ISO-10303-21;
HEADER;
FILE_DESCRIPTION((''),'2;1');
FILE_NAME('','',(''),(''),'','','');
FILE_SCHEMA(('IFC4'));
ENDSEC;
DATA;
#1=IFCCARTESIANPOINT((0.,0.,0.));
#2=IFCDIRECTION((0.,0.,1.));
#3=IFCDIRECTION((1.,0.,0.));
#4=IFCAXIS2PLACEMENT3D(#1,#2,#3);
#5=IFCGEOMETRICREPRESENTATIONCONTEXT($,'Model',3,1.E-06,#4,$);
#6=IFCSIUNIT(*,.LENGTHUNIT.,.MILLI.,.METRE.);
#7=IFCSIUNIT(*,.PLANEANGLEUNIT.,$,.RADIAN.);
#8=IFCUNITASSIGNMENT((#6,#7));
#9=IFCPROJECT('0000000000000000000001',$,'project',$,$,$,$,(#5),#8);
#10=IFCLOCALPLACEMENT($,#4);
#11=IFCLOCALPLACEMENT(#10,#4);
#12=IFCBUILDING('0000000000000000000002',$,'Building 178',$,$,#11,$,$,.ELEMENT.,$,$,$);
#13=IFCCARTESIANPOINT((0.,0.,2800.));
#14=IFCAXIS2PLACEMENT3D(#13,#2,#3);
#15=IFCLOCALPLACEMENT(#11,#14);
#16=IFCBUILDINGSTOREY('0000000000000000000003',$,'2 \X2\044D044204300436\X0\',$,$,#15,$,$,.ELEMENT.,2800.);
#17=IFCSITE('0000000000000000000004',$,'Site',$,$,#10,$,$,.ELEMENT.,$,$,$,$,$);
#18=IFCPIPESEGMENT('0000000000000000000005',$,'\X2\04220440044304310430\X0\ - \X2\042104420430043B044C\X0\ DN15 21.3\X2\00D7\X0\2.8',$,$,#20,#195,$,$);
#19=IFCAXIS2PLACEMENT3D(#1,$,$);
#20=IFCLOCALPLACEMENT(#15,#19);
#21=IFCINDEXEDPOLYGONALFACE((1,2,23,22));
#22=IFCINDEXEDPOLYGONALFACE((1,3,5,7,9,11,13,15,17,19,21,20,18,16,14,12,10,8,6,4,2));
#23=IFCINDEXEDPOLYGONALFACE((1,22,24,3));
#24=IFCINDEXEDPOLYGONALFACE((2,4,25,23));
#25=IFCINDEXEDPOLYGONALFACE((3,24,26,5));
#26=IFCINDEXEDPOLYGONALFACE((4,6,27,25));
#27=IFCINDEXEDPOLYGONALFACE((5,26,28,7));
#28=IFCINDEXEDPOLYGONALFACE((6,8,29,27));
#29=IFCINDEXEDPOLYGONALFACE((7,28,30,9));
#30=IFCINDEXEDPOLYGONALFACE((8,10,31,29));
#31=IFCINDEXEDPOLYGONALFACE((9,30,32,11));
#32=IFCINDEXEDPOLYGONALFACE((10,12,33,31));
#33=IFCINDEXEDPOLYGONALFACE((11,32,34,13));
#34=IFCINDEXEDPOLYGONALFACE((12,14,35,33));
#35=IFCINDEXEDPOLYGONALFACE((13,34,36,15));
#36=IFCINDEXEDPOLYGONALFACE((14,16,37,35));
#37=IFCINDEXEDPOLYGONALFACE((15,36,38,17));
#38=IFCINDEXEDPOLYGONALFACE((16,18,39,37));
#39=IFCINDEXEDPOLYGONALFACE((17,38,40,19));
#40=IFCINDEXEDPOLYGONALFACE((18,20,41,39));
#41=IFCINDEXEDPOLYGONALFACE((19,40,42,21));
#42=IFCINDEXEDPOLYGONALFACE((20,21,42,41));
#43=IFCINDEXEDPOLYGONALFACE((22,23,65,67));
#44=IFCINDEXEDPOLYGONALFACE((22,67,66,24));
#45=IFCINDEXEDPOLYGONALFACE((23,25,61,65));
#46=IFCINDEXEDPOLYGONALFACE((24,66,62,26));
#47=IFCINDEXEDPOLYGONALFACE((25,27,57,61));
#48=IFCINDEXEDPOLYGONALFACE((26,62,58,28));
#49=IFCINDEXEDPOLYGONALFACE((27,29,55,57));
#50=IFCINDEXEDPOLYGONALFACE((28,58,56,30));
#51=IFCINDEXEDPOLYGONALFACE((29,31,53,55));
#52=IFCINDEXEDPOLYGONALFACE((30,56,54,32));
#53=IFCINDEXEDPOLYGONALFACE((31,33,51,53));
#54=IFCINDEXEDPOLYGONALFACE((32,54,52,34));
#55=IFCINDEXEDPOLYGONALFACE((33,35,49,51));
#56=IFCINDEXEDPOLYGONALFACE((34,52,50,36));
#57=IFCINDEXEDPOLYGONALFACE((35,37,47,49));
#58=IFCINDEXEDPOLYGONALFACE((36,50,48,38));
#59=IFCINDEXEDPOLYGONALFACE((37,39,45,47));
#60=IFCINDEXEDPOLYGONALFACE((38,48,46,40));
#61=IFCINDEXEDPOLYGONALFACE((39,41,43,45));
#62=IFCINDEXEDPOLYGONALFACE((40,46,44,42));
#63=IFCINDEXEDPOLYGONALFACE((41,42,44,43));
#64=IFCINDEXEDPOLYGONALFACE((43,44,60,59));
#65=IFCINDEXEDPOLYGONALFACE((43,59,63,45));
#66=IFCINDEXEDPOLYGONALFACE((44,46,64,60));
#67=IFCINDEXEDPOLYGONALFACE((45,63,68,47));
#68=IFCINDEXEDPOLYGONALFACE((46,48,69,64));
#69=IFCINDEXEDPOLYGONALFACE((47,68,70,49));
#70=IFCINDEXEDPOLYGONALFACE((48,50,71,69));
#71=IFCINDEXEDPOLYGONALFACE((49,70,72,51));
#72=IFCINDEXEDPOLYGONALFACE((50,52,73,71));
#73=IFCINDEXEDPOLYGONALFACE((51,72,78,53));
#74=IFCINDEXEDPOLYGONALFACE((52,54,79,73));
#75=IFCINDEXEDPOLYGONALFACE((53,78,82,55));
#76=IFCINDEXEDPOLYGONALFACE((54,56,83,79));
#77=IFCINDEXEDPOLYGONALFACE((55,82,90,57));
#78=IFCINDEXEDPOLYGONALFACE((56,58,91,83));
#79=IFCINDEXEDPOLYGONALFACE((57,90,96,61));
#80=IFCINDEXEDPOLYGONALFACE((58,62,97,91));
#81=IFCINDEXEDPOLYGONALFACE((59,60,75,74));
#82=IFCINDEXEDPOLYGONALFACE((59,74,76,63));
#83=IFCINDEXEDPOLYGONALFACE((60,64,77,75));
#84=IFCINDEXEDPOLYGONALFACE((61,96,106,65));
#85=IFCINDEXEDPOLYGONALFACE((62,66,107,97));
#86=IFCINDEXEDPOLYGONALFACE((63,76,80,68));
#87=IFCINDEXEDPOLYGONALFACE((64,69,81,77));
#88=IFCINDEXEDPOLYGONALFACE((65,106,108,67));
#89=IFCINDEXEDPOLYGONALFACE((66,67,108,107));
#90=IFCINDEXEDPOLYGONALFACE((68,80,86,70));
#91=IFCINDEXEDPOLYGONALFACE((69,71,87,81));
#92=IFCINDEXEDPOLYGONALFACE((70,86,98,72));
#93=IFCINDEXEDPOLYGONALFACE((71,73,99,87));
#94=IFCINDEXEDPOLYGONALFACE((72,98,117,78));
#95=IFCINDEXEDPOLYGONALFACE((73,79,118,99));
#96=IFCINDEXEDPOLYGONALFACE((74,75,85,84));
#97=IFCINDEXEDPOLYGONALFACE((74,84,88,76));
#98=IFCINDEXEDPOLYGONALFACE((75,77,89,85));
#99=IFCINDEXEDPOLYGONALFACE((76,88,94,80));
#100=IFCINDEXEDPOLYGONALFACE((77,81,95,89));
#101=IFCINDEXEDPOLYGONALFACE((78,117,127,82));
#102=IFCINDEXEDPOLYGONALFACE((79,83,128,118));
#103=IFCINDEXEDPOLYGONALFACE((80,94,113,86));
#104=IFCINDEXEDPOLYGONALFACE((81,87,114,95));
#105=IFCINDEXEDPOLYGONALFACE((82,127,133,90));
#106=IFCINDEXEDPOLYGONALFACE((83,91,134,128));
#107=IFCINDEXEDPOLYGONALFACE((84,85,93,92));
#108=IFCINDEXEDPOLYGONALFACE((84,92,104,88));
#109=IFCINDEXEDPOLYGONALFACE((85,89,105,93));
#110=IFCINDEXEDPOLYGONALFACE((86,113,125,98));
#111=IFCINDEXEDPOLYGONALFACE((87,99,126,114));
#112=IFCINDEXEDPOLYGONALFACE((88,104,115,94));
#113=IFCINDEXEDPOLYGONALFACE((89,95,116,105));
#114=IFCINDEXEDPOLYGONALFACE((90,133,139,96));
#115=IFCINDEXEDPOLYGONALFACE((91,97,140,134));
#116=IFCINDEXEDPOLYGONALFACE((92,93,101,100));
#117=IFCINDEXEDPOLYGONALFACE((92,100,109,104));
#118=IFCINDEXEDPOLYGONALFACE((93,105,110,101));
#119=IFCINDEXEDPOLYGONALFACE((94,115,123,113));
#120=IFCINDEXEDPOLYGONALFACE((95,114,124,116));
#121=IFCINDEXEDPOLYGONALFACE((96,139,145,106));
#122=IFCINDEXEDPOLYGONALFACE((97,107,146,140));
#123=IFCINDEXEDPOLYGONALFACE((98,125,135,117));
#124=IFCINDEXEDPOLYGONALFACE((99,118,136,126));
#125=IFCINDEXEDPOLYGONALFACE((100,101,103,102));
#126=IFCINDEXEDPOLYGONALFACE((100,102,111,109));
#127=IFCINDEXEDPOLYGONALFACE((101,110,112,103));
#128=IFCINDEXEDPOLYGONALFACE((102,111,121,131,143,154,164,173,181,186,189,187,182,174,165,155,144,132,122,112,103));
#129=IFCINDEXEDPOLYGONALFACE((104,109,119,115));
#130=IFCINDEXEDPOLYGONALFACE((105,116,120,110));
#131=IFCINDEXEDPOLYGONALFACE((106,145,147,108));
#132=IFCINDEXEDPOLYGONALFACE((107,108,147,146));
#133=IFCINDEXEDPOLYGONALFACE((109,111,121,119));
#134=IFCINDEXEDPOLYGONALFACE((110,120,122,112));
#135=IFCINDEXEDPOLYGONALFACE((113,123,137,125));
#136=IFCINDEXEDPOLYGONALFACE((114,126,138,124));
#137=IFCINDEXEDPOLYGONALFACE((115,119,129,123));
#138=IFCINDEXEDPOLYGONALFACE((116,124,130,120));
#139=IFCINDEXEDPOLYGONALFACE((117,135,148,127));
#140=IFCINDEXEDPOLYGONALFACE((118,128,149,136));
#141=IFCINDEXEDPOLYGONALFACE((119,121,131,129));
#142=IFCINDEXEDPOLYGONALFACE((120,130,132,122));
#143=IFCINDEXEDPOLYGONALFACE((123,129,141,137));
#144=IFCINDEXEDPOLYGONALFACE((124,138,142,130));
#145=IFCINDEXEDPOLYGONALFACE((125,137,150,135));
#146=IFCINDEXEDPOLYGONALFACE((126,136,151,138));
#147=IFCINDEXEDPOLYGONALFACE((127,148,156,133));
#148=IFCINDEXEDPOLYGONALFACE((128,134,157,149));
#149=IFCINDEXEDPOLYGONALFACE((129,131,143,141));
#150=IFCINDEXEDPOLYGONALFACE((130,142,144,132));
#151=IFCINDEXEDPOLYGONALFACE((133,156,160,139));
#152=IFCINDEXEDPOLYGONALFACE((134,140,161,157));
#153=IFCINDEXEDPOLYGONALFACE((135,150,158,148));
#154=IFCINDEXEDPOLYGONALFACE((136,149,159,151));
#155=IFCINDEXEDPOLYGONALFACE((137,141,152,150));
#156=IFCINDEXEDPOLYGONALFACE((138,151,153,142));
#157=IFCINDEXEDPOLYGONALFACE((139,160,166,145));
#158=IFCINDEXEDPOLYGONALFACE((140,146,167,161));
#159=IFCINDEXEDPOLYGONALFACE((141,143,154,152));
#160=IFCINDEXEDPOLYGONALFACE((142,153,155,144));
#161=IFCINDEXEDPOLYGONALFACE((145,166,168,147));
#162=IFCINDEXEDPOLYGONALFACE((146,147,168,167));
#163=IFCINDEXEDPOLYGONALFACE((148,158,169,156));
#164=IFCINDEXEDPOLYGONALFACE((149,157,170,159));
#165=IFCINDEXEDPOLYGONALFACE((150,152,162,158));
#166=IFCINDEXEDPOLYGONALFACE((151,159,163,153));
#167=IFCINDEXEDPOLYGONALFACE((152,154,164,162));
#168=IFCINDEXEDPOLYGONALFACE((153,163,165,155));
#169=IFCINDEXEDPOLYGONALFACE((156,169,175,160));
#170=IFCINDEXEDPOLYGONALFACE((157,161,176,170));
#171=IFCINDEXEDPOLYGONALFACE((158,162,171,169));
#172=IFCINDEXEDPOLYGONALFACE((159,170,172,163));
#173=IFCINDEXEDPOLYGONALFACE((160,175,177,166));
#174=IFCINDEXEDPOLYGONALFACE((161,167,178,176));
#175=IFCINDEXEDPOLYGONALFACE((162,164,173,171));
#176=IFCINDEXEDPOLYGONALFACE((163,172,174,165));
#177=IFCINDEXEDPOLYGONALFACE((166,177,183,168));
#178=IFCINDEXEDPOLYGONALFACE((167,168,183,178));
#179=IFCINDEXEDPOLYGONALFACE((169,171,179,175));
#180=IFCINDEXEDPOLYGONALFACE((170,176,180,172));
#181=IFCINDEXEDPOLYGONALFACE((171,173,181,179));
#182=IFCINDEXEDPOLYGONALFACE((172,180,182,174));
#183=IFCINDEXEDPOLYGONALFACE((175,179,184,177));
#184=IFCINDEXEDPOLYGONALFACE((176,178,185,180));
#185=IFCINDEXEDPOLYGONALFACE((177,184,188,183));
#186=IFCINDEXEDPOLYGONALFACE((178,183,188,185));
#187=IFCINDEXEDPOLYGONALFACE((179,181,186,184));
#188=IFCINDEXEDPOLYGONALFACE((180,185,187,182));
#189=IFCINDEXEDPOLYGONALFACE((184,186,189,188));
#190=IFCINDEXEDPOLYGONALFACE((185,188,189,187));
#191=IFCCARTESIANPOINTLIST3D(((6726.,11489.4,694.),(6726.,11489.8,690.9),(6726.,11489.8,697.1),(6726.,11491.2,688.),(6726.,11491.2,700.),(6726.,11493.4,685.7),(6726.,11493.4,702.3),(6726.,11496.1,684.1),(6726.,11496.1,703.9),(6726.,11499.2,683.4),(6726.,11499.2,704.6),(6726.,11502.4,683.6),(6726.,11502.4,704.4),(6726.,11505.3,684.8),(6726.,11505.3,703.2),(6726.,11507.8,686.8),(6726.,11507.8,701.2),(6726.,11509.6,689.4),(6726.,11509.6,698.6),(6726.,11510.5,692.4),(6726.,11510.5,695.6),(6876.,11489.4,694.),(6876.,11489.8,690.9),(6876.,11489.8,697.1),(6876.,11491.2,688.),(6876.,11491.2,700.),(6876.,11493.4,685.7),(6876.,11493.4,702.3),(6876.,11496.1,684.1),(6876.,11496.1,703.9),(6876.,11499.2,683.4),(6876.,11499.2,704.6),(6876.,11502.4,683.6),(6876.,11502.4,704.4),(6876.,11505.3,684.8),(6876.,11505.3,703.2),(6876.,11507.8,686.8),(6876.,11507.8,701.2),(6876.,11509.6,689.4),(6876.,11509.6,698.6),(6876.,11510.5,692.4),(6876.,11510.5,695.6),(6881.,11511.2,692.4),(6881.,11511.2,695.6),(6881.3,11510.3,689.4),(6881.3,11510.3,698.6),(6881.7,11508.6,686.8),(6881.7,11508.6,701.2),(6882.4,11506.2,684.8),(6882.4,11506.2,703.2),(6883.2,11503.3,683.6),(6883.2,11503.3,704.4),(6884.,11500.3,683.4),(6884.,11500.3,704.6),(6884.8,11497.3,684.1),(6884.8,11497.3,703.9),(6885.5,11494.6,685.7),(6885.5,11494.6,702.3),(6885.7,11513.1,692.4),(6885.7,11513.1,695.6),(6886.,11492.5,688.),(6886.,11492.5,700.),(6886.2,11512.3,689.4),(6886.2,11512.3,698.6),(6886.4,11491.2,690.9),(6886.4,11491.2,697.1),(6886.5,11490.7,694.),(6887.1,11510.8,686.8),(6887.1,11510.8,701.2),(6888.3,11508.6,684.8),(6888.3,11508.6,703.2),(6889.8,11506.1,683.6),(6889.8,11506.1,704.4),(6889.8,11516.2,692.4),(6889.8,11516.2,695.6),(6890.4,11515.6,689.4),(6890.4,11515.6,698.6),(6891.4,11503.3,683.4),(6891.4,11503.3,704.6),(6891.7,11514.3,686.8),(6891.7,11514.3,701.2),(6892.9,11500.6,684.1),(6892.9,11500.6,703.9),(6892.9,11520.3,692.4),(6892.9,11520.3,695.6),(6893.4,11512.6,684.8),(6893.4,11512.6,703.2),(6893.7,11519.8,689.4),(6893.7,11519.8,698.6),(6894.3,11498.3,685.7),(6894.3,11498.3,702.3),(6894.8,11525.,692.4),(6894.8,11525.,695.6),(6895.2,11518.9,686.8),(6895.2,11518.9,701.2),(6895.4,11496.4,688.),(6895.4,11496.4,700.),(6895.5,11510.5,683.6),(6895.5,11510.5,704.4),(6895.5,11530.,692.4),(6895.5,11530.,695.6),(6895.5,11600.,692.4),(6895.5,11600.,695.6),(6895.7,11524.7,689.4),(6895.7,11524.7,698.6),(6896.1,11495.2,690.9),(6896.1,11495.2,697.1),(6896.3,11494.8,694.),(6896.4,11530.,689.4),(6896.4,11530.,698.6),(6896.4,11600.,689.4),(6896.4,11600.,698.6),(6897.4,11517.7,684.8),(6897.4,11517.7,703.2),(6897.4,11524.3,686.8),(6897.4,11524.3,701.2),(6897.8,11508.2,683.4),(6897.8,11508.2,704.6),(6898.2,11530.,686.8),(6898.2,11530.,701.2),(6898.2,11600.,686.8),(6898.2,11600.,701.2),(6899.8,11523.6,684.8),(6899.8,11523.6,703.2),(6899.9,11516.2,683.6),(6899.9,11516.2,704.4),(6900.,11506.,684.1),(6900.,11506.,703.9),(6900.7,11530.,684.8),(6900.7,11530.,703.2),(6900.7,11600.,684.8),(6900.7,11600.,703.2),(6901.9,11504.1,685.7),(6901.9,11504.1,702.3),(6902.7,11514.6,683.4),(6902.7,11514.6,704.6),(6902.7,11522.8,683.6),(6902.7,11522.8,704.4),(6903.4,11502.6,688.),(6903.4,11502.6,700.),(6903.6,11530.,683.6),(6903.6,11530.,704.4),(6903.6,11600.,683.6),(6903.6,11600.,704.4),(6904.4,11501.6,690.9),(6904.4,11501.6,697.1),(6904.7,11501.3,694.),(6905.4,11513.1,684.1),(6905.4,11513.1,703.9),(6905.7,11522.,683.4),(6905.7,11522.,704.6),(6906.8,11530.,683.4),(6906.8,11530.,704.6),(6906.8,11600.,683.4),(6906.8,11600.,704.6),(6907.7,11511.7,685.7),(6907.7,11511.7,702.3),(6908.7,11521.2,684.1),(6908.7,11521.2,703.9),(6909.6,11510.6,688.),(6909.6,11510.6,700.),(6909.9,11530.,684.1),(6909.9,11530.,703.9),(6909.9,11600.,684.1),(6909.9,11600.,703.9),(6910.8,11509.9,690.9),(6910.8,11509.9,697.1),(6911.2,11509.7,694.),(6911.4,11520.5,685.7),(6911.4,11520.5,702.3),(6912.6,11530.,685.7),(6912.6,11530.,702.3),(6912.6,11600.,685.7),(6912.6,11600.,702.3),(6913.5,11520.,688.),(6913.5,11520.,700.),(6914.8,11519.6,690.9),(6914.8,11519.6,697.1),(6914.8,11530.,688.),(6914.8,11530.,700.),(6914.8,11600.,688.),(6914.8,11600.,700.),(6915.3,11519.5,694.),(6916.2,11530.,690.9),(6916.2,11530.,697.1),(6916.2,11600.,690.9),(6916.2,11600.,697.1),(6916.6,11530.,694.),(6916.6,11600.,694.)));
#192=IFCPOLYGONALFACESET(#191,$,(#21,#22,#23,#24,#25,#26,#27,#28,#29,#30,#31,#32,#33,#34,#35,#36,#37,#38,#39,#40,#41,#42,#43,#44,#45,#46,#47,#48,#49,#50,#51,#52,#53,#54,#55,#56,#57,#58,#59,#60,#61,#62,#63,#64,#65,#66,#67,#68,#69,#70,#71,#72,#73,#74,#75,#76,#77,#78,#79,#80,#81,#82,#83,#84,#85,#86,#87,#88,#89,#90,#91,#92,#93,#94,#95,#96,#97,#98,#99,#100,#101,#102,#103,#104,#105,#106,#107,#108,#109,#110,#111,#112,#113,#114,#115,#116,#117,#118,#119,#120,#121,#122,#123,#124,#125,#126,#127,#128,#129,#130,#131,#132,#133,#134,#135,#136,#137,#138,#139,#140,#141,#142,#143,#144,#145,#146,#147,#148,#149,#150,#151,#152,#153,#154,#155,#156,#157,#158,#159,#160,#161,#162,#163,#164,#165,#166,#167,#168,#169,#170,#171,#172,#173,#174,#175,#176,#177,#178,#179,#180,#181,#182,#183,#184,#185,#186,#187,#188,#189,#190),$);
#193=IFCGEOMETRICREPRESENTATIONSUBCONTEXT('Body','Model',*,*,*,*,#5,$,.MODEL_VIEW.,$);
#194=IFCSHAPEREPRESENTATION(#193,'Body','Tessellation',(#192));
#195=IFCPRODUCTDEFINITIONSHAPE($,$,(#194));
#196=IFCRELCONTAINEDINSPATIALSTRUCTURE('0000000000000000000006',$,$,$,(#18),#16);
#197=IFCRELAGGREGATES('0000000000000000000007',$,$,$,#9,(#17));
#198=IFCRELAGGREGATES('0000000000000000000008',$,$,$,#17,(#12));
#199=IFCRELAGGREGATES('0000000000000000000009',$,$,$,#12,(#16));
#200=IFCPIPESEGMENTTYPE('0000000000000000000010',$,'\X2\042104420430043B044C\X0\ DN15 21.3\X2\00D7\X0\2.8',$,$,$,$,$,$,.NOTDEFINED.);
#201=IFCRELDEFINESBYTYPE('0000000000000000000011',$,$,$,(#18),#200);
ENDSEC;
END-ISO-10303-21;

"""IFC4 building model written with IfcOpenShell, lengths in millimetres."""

from ifc_helpers import new_model, entity, si_unit, frame, origin_with_axes, place, context, subcontext, project, spatial, source, transform, mapped, type_object, element, save


model = new_model("IFC4")

# Units and contexts
model_context = context("Model", 3, precision=1e-06, world=origin_with_axes())
body_context = subcontext(model_context, "Body", "Model", "MODEL_VIEW")
ifc_project = project(units=[si_unit("LENGTHUNIT", "METRE", prefix="MILLI"), si_unit("PLANEANGLEUNIT", "RADIAN")], contexts=[model_context])

# Site, building, storey
site_placement = place(None, origin_with_axes())
site = spatial("IfcSite", under=ifc_project, at=site_placement, Name="Site", CompositionType="ELEMENT")
building_placement = place(site_placement, origin_with_axes())
building = spatial("IfcBuilding", under=site, at=building_placement, Name="Building 178", CompositionType="ELEMENT")
storey_placement = place(building_placement, frame((0.0, 0.0, 2800.0), z_axis=(0.0, 0.0, 1.0), x_axis=(1.0, 0.0, 0.0)))
storey = spatial("IfcBuildingStorey", under=building, at=storey_placement, Name="2 этаж", CompositionType="ELEMENT", Elevation=2800.0)

# Pipe segment
pipe_segment_type = type_object("IfcPipeSegmentType", Name="Сталь DN15 21.3×2.8", PredefinedType="NOTDEFINED")
shared_shape_1 = source(origin_with_axes(), body_context, "Body", "AdvancedSweptSolid", [
    entity("IfcSweptDiskSolid", entity("IfcIndexedPolyCurve", entity("IfcCartesianPointList3D", [[0.0, 0.0, 0.0], [0.0, 0.0, -70.0], [8.8, 0.0, -91.2], [30.0, 0.0, -100.0], [180.0, 0.0, -100.0]]), [entity("IfcLineIndex", [1, 2]), entity("IfcArcIndex", [2, 3, 4]), entity("IfcLineIndex", [4, 5])]), 10.7),
])
for number, where, z_axis, x_axis, name in (
    (1, (6906.0, 11600.0, 694.0), (0.0, 1.0, 0.0), (-1.0, 0.0, 0.0), "Труба - Сталь DN15 21.3×2.8"),
):
    element("IfcPipeSegment", number, at=place(storey_placement, frame(where, z_axis=z_axis, x_axis=x_axis)), inside=storey, type_object=pipe_segment_type, Name=name, context=body_context, shape_type="MappedRepresentation", body=[
        mapped(shared_shape_1, transform((0.0, 0.0, 0.0), x_axis=(1.0, 0.0, 0.0), y_axis=(0.0, 1.0, 0.0), z_axis=(0.0, 0.0, 1.0), scale=1.0)),
    ])

save(model, "model.ifc")
